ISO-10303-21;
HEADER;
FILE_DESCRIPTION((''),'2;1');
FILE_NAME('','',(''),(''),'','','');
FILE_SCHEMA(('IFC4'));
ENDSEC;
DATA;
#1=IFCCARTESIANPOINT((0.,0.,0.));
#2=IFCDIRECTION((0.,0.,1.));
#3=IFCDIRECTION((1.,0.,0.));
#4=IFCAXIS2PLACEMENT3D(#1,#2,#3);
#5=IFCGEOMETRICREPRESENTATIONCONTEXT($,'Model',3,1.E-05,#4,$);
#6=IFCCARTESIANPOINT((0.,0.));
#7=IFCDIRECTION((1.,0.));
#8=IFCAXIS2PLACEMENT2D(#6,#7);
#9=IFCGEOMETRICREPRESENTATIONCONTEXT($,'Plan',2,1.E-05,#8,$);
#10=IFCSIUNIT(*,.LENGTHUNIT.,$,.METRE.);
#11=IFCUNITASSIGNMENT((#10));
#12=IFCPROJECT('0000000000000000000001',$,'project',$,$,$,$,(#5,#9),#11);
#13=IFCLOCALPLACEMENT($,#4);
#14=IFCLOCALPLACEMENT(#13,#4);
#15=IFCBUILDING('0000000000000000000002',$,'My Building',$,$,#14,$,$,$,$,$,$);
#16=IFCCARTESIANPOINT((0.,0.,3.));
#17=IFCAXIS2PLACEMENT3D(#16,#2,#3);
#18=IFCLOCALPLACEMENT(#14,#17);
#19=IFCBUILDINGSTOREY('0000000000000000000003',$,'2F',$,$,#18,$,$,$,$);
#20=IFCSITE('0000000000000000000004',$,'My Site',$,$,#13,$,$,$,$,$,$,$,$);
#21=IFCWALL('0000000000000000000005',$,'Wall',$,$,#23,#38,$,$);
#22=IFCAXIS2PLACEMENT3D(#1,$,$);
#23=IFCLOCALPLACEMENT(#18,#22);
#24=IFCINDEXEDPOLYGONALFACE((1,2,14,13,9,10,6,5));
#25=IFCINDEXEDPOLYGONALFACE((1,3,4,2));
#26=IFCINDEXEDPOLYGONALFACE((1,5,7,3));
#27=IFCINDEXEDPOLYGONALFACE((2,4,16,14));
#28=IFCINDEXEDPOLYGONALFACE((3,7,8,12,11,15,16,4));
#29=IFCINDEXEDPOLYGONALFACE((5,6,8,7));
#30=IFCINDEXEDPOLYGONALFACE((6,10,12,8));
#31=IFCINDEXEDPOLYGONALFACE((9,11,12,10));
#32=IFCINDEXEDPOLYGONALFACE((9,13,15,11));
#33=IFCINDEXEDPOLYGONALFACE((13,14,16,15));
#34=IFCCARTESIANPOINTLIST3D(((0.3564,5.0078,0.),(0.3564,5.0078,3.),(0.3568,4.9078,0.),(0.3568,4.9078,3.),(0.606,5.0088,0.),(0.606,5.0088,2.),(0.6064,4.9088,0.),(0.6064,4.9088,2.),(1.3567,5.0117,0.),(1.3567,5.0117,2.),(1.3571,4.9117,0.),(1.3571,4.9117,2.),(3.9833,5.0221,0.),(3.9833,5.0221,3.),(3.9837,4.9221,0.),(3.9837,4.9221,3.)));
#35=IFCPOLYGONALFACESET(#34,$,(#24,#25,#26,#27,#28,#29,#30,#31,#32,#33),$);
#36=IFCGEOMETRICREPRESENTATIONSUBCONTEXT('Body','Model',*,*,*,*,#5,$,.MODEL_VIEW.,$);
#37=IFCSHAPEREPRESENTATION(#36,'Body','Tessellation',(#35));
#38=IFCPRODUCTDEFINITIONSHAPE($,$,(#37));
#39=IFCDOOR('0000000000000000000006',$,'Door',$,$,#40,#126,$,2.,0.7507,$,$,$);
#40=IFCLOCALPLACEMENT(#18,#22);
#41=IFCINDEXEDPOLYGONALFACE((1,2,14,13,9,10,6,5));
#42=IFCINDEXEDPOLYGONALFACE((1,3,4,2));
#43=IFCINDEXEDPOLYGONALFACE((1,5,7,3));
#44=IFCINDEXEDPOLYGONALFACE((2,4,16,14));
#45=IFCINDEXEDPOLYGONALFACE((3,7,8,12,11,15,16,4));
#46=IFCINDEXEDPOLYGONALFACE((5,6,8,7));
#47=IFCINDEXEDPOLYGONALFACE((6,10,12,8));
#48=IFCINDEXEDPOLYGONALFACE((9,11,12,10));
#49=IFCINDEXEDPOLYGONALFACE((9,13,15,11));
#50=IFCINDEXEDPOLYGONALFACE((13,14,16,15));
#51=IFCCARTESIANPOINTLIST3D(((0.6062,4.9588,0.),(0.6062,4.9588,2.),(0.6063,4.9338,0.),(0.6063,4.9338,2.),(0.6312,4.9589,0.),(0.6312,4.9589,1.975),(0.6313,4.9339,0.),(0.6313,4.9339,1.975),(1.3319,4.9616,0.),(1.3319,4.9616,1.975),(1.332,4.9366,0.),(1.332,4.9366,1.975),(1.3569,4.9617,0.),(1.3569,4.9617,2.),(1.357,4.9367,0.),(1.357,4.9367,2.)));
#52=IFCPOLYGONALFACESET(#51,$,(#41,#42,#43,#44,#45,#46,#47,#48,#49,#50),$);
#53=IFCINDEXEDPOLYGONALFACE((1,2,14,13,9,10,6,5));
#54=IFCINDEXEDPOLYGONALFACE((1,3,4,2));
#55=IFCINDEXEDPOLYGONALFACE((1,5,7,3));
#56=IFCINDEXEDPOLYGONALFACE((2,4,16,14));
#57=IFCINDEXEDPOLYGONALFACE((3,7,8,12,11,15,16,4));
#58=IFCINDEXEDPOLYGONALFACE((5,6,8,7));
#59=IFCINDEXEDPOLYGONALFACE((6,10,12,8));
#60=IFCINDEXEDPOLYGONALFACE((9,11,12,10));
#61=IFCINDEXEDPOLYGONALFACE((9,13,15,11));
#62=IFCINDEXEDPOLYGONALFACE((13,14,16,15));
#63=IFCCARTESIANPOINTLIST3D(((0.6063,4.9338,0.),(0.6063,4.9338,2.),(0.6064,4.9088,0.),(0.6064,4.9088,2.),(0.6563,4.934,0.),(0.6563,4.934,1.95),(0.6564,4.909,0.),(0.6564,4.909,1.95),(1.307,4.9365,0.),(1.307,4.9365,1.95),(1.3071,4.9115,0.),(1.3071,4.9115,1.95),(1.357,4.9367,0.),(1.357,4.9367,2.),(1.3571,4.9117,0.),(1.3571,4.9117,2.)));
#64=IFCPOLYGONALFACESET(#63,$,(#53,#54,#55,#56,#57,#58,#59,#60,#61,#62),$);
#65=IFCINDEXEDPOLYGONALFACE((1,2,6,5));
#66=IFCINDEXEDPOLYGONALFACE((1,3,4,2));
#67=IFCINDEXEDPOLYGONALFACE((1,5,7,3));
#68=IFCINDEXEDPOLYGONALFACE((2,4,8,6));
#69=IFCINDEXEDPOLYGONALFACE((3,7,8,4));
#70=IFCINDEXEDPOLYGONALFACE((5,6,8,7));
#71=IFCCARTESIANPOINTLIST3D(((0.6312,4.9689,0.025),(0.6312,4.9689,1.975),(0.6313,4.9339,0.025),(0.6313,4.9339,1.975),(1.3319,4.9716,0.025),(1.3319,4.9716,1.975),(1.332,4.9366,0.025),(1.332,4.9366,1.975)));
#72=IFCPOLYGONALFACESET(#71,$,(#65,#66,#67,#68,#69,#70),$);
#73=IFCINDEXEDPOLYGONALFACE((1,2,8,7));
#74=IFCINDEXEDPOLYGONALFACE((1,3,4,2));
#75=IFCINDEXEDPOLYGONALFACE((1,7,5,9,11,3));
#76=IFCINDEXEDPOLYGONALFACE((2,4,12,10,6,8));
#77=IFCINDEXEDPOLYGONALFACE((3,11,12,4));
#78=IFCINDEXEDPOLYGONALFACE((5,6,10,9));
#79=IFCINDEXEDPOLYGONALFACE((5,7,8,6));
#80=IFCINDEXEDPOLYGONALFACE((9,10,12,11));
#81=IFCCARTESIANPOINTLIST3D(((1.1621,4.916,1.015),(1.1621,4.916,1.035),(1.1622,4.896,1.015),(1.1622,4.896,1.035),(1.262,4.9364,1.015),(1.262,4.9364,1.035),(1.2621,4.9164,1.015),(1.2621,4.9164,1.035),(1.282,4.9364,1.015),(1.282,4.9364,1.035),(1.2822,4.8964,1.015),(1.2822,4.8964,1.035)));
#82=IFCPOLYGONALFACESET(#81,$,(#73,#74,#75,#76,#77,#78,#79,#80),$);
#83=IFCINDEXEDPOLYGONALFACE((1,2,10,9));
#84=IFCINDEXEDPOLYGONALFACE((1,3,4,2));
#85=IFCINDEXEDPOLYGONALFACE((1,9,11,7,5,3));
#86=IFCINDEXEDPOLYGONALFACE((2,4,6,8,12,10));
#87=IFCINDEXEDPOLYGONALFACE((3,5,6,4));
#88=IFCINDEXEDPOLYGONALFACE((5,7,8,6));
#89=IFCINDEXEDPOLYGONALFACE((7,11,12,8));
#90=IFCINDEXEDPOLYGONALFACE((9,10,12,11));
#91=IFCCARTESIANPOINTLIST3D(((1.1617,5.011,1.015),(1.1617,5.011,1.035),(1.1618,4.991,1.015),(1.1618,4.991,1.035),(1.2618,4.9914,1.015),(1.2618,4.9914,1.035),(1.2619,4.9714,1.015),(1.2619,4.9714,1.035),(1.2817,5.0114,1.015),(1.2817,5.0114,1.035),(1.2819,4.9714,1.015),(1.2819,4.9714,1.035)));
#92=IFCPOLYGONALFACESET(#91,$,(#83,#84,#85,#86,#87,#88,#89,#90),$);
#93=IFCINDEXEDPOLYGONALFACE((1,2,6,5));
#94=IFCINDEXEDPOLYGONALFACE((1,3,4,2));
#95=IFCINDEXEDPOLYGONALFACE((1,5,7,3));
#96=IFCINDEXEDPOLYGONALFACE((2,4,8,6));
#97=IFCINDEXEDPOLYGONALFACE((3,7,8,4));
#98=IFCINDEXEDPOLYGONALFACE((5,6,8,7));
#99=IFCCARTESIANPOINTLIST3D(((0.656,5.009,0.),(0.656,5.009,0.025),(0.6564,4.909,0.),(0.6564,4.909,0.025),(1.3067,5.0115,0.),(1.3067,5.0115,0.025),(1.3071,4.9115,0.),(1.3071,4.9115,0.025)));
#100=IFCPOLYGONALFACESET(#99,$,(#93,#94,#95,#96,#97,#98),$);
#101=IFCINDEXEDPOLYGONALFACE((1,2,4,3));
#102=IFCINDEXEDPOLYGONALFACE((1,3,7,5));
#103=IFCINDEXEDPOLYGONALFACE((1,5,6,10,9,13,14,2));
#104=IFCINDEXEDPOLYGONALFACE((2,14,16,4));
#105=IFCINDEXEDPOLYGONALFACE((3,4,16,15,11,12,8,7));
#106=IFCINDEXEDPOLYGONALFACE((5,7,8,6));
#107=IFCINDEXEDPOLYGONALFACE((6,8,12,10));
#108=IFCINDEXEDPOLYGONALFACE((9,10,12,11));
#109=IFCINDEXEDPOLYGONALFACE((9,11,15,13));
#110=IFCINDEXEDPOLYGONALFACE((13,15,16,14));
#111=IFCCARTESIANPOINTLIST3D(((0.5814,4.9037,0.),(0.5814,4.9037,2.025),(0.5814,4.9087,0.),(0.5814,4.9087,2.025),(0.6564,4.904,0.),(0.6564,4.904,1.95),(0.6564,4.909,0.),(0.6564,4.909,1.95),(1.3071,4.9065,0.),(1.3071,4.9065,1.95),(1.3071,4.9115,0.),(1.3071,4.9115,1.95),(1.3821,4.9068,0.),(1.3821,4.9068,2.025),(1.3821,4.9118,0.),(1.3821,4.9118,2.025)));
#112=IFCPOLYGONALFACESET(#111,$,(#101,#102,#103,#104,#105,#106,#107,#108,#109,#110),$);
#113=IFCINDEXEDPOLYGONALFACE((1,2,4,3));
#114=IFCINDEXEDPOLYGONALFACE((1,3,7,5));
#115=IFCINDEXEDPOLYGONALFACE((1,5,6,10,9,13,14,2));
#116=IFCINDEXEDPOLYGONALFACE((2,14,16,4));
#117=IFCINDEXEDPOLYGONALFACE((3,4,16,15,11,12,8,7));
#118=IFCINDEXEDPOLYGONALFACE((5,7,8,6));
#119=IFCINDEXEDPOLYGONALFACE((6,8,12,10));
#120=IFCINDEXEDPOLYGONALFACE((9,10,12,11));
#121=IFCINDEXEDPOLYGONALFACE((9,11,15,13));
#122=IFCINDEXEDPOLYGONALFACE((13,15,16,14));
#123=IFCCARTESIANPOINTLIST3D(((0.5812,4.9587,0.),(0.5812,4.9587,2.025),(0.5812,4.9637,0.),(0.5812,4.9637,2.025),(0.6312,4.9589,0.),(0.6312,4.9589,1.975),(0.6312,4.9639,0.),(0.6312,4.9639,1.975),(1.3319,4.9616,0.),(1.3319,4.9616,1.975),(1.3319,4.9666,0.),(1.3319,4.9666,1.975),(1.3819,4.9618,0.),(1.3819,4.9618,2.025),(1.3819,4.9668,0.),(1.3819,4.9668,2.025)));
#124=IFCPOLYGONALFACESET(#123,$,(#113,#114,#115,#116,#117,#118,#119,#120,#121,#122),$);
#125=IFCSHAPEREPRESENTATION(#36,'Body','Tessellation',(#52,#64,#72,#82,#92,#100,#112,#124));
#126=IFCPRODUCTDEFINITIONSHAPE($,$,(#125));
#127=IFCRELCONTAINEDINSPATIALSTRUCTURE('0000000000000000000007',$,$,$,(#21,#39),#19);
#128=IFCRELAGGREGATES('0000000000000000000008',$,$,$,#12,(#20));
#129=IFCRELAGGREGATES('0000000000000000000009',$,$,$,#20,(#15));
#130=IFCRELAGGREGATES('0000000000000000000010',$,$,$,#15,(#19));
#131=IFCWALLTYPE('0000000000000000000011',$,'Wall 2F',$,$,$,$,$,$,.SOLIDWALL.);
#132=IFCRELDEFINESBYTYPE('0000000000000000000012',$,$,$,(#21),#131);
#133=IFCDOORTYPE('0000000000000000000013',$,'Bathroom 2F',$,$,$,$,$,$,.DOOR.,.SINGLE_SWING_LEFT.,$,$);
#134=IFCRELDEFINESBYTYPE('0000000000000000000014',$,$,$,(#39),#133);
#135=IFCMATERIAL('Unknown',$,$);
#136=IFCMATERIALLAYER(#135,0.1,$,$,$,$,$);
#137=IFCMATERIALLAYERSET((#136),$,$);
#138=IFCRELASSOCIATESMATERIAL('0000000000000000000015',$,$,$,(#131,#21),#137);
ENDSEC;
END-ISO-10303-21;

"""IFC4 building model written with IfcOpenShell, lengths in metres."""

from ifc_helpers import new_model, entity, si_unit, frame, origin_with_axes, origin_2d_with_axis, place, context, subcontext, project, spatial, line, indexed_curve, outline, extrude, shape, source, transform, mapped, material, layer, layer_set, layer_usage, type_object, type_shapes, element, fill, save


model = new_model("IFC4")

# Units and contexts
model_context = context("Model", 3, precision=1e-05, world=origin_with_axes())
plan_context = context("Plan", 2, precision=1e-05, world=origin_2d_with_axis())
body_context_1 = subcontext(model_context, "Body", "Model", "MODEL_VIEW")
body_context_2 = subcontext(plan_context, "Body", "Plan", "PLAN_VIEW")
ifc_project = project(units=[si_unit("LENGTHUNIT", "METRE")], contexts=[model_context, plan_context])

# Site, building, storey
site_placement = place(None, origin_with_axes())
site = spatial("IfcSite", under=ifc_project, at=site_placement, Name="My Site")
building_placement = place(site_placement, origin_with_axes())
building = spatial("IfcBuilding", under=site, at=building_placement, Name="My Building")
storey_placement = place(building_placement, frame((0.0, 0.0, 3.0), z_axis=(0.0, 0.0, 1.0), x_axis=(1.0, 0.0, 0.0)))
storey = spatial("IfcBuildingStorey", under=building, at=storey_placement, Name="2F")

# Shared definitions
ifc_material = material(Name="Unknown")

# Shared definitions
ifc_layer = layer(ifc_material, 0.1)
ifc_layer_set = layer_set([ifc_layer])
wall_type = type_object("IfcWallType", Name="Wall 2F", PredefinedType="SOLIDWALL", material=ifc_layer_set)

# Wall, opening, door
ifc_layer_usage_1 = layer_usage(ifc_layer_set, "AXIS2", "POSITIVE", 0.0)
wall_1_placement = place(storey_placement, frame((3.9833, 5.0221, 0.0), z_axis=(0.0, 0.0, 1.0), x_axis=(-0.999992, -0.00394, 0.0)))
wall_1 = element("IfcWall", 1, at=wall_1_placement, inside=storey, type_object=wall_type, material=ifc_layer_usage_1, Name="Wall", context=body_context_1, shape_type="SweptSolid", body=[
    extrude(outline(indexed_curve([(0.0, 0.0), (0.0, 0.1), (3.627, 0.1), (3.627, 0.0)], segments=[line(1, 2, 3, 4, 1)])), origin_with_axes(), (0.0, 0.0, 1.0), 3.0),
])
shared_shape_1 = source(origin_with_axes(), body_context_1, "Body", "SweptSolid", [
    extrude(outline(indexed_curve([(0.0, 0.0), (0.7507, 0.0), (0.7507, 2.0), (0.0, 2.0)], segments=[line(1, 2, 3, 4, 1)])), frame((0.0, -0.6, 0.0), z_axis=(0.0, -1.0, 0.0), x_axis=(1.0, 0.0, 0.0)), (0.0, 0.0, -1.0), 1.2),
])
opening_1_placement = place(wall_1_placement, frame((3.3773, 0.1, 0.0), z_axis=(0.0, 0.0, 1.0), x_axis=(-1.0, 0.0, 0.0)))
opening_1 = element("IfcOpeningElement", 2, at=opening_1_placement, cuts=wall_1, PredefinedType="OPENING", context=body_context_1, shape_type="MappedRepresentation", body=[
    mapped(shared_shape_1, transform((0.0, 0.0, 0.0), x_axis=(1.0, 0.0, 0.0), y_axis=(0.0, 1.0, 0.0), z_axis=(0.0, 0.0, 1.0), scale=1.0)),
])
door_type_1 = type_object("IfcDoorType", Name="Bathroom 2F", OperationType="SINGLE_SWING_LEFT", PredefinedType="DOOR")
shared_shape_2 = source(origin_with_axes(), body_context_1, "Body", "SweptSolid", [
    extrude(outline(indexed_curve([(0.0, 0.0), (0.0, 2.0), (0.7507, 2.0), (0.7507, 0.0), (0.7257, 0.0), (0.7257, 1.975), (0.025, 1.975), (0.025, 0.0)], segments=[line(1, 2, 3, 4, 5, 6, 7, 8, 1)])), frame((0.0, 0.025, 0.0), z_axis=(0.0, -1.0, 0.0), x_axis=(1.0, 0.0, 0.0)), (0.0, 0.0, -1.0), 0.025),
    extrude(outline(indexed_curve([(0.0, 0.0), (0.0, 2.0), (0.7507, 2.0), (0.7507, 0.0), (0.7007, 0.0), (0.7007, 1.95), (0.05, 1.95), (0.05, 0.0)], segments=[line(1, 2, 3, 4, 5, 6, 7, 8, 1)])), frame((0.0, 0.0, 0.0), z_axis=(0.0, -1.0, 0.0), x_axis=(1.0, 0.0, 0.0)), (0.0, 0.0, -1.0), 0.025),
    extrude(outline(indexed_curve([(0.0, 0.0), (0.7007, 0.0), (0.7007, 0.035), (0.0, 0.035)], segments=[line(1, 2, 3, 4, 1)])), frame((0.025, 0.025, 0.025), z_axis=(0.0, 0.0, 1.0), x_axis=(1.0, 0.0, 0.0)), (0.0, 0.0, 1.0), 1.95),
    extrude(outline(indexed_curve([(0.0, 0.0), (0.0, -0.04), (-0.12, -0.04), (-0.12, -0.02), (-0.02, -0.02), (-0.02, 0.0)], segments=[line(1, 2, 3, 4, 5, 6, 1)])), frame((0.6757, 0.025, 1.015), z_axis=(0.0, 0.0, 1.0), x_axis=(1.0, 0.0, 0.0)), (0.0, 0.0, 1.0), 0.02),
    extrude(outline(indexed_curve([(0.0, 0.0), (0.0, 0.04), (-0.12, 0.04), (-0.12, 0.02), (-0.02, 0.02), (-0.02, 0.0)], segments=[line(1, 2, 3, 4, 5, 6, 1)])), frame((0.6757, 0.06, 1.015), z_axis=(0.0, 0.0, 1.0), x_axis=(1.0, 0.0, 0.0)), (0.0, 0.0, 1.0), 0.02),
    extrude(outline(indexed_curve([(0.0, 0.0), (0.6507, 0.0), (0.6507, 0.1), (0.0, 0.1)], segments=[line(1, 2, 3, 4, 1)])), frame((0.05, 0.0, 0.0), z_axis=(0.0, 0.0, 1.0), x_axis=(1.0, 0.0, 0.0)), (0.0, 0.0, 1.0), 0.025),
    extrude(outline(indexed_curve([(0.0, 0.0), (0.0, 2.025), (0.8007, 2.025), (0.8007, 0.0), (0.7257, 0.0), (0.7257, 1.95), (0.075, 1.95), (0.075, 0.0)], segments=[line(1, 2, 3, 4, 5, 6, 7, 8, 1)])), frame((-0.025, -0.005, 0.0), z_axis=(0.0, -1.0, 0.0), x_axis=(1.0, 0.0, 0.0)), (0.0, 0.0, -1.0), 0.005),
    extrude(outline(indexed_curve([(0.0, 0.0), (0.0, 2.025), (0.8007, 2.025), (0.8007, 0.0), (0.7507, 0.0), (0.7507, 1.975), (0.05, 1.975), (0.05, 0.0)], segments=[line(1, 2, 3, 4, 5, 6, 7, 8, 1)])), frame((-0.025, 0.05, 0.0), z_axis=(0.0, -1.0, 0.0), x_axis=(1.0, 0.0, 0.0)), (0.0, 0.0, -1.0), 0.005),
])
shared_shape_3 = source(origin_with_axes(), body_context_2, "Body", "Curve2D", [
    entity("IfcIndexedPolyCurve", entity("IfcCartesianPointList2D", [[0.0, 0.0], [0.0, 0.05], [0.025, 0.05], [0.025, 0.025], [0.05, 0.025], [0.05, 0.0]]), [entity("IfcLineIndex", [1, 2, 3, 4, 5, 6, 1])]),
    entity("IfcIndexedPolyCurve", entity("IfcCartesianPointList2D", [[0.7507, 0.0], [0.7507, 0.05], [0.7257, 0.05], [0.7257, 0.025], [0.7007, 0.025], [0.7007, 0.0]]), [entity("IfcLineIndex", [1, 2, 3, 4, 5, 6, 1])]),
    entity("IfcTrimmedCurve", entity("IfcEllipse", entity("IfcAxis2Placement2D", entity("IfcCartesianPoint", [0.06, 0.05]), entity("IfcDirection", [1.0, 0.0])), 0.6657, 0.7007), [entity("IfcCartesianPoint", [0.7257, 0.05])], [entity("IfcCartesianPoint", [0.06, 0.7507])], True, "CARTESIAN"),
    entity("IfcIndexedPolyCurve", entity("IfcCartesianPointList2D", [[0.025, 0.05], [0.06, 0.05], [0.06, 0.7507], [0.025, 0.7507]]), [entity("IfcLineIndex", [1, 2, 3, 4, 1])]),
])
type_shapes(door_type_1, [shared_shape_2, shared_shape_3])
door_1_placement = place(opening_1_placement, frame((0.0, 0.0, 0.0), z_axis=(0.0, 0.0, 1.0), x_axis=(1.0, 0.0, 0.0)))
door_1 = element("IfcDoor", 3, at=door_1_placement, inside=storey, type_object=door_type_1, Name="Door", OverallHeight=2.0, OverallWidth=0.7507, shapes=[
    shape(body_context_1, "Body", "MappedRepresentation", [mapped(shared_shape_2, transform((0.0, 0.0, 0.0), x_axis=(1.0, 0.0, 0.0), y_axis=(0.0, 1.0, 0.0), z_axis=(0.0, 0.0, 1.0), scale=1.0))]),
    shape(body_context_2, "Body", "MappedRepresentation", [mapped(shared_shape_3, transform((0.0, 0.0, 0.0), x_axis=(1.0, 0.0, 0.0), y_axis=(0.0, 1.0, 0.0), z_axis=(0.0, 0.0, 1.0), scale=1.0))]),
])
fill(opening_1, door_1)

save(model, "model.ifc")
